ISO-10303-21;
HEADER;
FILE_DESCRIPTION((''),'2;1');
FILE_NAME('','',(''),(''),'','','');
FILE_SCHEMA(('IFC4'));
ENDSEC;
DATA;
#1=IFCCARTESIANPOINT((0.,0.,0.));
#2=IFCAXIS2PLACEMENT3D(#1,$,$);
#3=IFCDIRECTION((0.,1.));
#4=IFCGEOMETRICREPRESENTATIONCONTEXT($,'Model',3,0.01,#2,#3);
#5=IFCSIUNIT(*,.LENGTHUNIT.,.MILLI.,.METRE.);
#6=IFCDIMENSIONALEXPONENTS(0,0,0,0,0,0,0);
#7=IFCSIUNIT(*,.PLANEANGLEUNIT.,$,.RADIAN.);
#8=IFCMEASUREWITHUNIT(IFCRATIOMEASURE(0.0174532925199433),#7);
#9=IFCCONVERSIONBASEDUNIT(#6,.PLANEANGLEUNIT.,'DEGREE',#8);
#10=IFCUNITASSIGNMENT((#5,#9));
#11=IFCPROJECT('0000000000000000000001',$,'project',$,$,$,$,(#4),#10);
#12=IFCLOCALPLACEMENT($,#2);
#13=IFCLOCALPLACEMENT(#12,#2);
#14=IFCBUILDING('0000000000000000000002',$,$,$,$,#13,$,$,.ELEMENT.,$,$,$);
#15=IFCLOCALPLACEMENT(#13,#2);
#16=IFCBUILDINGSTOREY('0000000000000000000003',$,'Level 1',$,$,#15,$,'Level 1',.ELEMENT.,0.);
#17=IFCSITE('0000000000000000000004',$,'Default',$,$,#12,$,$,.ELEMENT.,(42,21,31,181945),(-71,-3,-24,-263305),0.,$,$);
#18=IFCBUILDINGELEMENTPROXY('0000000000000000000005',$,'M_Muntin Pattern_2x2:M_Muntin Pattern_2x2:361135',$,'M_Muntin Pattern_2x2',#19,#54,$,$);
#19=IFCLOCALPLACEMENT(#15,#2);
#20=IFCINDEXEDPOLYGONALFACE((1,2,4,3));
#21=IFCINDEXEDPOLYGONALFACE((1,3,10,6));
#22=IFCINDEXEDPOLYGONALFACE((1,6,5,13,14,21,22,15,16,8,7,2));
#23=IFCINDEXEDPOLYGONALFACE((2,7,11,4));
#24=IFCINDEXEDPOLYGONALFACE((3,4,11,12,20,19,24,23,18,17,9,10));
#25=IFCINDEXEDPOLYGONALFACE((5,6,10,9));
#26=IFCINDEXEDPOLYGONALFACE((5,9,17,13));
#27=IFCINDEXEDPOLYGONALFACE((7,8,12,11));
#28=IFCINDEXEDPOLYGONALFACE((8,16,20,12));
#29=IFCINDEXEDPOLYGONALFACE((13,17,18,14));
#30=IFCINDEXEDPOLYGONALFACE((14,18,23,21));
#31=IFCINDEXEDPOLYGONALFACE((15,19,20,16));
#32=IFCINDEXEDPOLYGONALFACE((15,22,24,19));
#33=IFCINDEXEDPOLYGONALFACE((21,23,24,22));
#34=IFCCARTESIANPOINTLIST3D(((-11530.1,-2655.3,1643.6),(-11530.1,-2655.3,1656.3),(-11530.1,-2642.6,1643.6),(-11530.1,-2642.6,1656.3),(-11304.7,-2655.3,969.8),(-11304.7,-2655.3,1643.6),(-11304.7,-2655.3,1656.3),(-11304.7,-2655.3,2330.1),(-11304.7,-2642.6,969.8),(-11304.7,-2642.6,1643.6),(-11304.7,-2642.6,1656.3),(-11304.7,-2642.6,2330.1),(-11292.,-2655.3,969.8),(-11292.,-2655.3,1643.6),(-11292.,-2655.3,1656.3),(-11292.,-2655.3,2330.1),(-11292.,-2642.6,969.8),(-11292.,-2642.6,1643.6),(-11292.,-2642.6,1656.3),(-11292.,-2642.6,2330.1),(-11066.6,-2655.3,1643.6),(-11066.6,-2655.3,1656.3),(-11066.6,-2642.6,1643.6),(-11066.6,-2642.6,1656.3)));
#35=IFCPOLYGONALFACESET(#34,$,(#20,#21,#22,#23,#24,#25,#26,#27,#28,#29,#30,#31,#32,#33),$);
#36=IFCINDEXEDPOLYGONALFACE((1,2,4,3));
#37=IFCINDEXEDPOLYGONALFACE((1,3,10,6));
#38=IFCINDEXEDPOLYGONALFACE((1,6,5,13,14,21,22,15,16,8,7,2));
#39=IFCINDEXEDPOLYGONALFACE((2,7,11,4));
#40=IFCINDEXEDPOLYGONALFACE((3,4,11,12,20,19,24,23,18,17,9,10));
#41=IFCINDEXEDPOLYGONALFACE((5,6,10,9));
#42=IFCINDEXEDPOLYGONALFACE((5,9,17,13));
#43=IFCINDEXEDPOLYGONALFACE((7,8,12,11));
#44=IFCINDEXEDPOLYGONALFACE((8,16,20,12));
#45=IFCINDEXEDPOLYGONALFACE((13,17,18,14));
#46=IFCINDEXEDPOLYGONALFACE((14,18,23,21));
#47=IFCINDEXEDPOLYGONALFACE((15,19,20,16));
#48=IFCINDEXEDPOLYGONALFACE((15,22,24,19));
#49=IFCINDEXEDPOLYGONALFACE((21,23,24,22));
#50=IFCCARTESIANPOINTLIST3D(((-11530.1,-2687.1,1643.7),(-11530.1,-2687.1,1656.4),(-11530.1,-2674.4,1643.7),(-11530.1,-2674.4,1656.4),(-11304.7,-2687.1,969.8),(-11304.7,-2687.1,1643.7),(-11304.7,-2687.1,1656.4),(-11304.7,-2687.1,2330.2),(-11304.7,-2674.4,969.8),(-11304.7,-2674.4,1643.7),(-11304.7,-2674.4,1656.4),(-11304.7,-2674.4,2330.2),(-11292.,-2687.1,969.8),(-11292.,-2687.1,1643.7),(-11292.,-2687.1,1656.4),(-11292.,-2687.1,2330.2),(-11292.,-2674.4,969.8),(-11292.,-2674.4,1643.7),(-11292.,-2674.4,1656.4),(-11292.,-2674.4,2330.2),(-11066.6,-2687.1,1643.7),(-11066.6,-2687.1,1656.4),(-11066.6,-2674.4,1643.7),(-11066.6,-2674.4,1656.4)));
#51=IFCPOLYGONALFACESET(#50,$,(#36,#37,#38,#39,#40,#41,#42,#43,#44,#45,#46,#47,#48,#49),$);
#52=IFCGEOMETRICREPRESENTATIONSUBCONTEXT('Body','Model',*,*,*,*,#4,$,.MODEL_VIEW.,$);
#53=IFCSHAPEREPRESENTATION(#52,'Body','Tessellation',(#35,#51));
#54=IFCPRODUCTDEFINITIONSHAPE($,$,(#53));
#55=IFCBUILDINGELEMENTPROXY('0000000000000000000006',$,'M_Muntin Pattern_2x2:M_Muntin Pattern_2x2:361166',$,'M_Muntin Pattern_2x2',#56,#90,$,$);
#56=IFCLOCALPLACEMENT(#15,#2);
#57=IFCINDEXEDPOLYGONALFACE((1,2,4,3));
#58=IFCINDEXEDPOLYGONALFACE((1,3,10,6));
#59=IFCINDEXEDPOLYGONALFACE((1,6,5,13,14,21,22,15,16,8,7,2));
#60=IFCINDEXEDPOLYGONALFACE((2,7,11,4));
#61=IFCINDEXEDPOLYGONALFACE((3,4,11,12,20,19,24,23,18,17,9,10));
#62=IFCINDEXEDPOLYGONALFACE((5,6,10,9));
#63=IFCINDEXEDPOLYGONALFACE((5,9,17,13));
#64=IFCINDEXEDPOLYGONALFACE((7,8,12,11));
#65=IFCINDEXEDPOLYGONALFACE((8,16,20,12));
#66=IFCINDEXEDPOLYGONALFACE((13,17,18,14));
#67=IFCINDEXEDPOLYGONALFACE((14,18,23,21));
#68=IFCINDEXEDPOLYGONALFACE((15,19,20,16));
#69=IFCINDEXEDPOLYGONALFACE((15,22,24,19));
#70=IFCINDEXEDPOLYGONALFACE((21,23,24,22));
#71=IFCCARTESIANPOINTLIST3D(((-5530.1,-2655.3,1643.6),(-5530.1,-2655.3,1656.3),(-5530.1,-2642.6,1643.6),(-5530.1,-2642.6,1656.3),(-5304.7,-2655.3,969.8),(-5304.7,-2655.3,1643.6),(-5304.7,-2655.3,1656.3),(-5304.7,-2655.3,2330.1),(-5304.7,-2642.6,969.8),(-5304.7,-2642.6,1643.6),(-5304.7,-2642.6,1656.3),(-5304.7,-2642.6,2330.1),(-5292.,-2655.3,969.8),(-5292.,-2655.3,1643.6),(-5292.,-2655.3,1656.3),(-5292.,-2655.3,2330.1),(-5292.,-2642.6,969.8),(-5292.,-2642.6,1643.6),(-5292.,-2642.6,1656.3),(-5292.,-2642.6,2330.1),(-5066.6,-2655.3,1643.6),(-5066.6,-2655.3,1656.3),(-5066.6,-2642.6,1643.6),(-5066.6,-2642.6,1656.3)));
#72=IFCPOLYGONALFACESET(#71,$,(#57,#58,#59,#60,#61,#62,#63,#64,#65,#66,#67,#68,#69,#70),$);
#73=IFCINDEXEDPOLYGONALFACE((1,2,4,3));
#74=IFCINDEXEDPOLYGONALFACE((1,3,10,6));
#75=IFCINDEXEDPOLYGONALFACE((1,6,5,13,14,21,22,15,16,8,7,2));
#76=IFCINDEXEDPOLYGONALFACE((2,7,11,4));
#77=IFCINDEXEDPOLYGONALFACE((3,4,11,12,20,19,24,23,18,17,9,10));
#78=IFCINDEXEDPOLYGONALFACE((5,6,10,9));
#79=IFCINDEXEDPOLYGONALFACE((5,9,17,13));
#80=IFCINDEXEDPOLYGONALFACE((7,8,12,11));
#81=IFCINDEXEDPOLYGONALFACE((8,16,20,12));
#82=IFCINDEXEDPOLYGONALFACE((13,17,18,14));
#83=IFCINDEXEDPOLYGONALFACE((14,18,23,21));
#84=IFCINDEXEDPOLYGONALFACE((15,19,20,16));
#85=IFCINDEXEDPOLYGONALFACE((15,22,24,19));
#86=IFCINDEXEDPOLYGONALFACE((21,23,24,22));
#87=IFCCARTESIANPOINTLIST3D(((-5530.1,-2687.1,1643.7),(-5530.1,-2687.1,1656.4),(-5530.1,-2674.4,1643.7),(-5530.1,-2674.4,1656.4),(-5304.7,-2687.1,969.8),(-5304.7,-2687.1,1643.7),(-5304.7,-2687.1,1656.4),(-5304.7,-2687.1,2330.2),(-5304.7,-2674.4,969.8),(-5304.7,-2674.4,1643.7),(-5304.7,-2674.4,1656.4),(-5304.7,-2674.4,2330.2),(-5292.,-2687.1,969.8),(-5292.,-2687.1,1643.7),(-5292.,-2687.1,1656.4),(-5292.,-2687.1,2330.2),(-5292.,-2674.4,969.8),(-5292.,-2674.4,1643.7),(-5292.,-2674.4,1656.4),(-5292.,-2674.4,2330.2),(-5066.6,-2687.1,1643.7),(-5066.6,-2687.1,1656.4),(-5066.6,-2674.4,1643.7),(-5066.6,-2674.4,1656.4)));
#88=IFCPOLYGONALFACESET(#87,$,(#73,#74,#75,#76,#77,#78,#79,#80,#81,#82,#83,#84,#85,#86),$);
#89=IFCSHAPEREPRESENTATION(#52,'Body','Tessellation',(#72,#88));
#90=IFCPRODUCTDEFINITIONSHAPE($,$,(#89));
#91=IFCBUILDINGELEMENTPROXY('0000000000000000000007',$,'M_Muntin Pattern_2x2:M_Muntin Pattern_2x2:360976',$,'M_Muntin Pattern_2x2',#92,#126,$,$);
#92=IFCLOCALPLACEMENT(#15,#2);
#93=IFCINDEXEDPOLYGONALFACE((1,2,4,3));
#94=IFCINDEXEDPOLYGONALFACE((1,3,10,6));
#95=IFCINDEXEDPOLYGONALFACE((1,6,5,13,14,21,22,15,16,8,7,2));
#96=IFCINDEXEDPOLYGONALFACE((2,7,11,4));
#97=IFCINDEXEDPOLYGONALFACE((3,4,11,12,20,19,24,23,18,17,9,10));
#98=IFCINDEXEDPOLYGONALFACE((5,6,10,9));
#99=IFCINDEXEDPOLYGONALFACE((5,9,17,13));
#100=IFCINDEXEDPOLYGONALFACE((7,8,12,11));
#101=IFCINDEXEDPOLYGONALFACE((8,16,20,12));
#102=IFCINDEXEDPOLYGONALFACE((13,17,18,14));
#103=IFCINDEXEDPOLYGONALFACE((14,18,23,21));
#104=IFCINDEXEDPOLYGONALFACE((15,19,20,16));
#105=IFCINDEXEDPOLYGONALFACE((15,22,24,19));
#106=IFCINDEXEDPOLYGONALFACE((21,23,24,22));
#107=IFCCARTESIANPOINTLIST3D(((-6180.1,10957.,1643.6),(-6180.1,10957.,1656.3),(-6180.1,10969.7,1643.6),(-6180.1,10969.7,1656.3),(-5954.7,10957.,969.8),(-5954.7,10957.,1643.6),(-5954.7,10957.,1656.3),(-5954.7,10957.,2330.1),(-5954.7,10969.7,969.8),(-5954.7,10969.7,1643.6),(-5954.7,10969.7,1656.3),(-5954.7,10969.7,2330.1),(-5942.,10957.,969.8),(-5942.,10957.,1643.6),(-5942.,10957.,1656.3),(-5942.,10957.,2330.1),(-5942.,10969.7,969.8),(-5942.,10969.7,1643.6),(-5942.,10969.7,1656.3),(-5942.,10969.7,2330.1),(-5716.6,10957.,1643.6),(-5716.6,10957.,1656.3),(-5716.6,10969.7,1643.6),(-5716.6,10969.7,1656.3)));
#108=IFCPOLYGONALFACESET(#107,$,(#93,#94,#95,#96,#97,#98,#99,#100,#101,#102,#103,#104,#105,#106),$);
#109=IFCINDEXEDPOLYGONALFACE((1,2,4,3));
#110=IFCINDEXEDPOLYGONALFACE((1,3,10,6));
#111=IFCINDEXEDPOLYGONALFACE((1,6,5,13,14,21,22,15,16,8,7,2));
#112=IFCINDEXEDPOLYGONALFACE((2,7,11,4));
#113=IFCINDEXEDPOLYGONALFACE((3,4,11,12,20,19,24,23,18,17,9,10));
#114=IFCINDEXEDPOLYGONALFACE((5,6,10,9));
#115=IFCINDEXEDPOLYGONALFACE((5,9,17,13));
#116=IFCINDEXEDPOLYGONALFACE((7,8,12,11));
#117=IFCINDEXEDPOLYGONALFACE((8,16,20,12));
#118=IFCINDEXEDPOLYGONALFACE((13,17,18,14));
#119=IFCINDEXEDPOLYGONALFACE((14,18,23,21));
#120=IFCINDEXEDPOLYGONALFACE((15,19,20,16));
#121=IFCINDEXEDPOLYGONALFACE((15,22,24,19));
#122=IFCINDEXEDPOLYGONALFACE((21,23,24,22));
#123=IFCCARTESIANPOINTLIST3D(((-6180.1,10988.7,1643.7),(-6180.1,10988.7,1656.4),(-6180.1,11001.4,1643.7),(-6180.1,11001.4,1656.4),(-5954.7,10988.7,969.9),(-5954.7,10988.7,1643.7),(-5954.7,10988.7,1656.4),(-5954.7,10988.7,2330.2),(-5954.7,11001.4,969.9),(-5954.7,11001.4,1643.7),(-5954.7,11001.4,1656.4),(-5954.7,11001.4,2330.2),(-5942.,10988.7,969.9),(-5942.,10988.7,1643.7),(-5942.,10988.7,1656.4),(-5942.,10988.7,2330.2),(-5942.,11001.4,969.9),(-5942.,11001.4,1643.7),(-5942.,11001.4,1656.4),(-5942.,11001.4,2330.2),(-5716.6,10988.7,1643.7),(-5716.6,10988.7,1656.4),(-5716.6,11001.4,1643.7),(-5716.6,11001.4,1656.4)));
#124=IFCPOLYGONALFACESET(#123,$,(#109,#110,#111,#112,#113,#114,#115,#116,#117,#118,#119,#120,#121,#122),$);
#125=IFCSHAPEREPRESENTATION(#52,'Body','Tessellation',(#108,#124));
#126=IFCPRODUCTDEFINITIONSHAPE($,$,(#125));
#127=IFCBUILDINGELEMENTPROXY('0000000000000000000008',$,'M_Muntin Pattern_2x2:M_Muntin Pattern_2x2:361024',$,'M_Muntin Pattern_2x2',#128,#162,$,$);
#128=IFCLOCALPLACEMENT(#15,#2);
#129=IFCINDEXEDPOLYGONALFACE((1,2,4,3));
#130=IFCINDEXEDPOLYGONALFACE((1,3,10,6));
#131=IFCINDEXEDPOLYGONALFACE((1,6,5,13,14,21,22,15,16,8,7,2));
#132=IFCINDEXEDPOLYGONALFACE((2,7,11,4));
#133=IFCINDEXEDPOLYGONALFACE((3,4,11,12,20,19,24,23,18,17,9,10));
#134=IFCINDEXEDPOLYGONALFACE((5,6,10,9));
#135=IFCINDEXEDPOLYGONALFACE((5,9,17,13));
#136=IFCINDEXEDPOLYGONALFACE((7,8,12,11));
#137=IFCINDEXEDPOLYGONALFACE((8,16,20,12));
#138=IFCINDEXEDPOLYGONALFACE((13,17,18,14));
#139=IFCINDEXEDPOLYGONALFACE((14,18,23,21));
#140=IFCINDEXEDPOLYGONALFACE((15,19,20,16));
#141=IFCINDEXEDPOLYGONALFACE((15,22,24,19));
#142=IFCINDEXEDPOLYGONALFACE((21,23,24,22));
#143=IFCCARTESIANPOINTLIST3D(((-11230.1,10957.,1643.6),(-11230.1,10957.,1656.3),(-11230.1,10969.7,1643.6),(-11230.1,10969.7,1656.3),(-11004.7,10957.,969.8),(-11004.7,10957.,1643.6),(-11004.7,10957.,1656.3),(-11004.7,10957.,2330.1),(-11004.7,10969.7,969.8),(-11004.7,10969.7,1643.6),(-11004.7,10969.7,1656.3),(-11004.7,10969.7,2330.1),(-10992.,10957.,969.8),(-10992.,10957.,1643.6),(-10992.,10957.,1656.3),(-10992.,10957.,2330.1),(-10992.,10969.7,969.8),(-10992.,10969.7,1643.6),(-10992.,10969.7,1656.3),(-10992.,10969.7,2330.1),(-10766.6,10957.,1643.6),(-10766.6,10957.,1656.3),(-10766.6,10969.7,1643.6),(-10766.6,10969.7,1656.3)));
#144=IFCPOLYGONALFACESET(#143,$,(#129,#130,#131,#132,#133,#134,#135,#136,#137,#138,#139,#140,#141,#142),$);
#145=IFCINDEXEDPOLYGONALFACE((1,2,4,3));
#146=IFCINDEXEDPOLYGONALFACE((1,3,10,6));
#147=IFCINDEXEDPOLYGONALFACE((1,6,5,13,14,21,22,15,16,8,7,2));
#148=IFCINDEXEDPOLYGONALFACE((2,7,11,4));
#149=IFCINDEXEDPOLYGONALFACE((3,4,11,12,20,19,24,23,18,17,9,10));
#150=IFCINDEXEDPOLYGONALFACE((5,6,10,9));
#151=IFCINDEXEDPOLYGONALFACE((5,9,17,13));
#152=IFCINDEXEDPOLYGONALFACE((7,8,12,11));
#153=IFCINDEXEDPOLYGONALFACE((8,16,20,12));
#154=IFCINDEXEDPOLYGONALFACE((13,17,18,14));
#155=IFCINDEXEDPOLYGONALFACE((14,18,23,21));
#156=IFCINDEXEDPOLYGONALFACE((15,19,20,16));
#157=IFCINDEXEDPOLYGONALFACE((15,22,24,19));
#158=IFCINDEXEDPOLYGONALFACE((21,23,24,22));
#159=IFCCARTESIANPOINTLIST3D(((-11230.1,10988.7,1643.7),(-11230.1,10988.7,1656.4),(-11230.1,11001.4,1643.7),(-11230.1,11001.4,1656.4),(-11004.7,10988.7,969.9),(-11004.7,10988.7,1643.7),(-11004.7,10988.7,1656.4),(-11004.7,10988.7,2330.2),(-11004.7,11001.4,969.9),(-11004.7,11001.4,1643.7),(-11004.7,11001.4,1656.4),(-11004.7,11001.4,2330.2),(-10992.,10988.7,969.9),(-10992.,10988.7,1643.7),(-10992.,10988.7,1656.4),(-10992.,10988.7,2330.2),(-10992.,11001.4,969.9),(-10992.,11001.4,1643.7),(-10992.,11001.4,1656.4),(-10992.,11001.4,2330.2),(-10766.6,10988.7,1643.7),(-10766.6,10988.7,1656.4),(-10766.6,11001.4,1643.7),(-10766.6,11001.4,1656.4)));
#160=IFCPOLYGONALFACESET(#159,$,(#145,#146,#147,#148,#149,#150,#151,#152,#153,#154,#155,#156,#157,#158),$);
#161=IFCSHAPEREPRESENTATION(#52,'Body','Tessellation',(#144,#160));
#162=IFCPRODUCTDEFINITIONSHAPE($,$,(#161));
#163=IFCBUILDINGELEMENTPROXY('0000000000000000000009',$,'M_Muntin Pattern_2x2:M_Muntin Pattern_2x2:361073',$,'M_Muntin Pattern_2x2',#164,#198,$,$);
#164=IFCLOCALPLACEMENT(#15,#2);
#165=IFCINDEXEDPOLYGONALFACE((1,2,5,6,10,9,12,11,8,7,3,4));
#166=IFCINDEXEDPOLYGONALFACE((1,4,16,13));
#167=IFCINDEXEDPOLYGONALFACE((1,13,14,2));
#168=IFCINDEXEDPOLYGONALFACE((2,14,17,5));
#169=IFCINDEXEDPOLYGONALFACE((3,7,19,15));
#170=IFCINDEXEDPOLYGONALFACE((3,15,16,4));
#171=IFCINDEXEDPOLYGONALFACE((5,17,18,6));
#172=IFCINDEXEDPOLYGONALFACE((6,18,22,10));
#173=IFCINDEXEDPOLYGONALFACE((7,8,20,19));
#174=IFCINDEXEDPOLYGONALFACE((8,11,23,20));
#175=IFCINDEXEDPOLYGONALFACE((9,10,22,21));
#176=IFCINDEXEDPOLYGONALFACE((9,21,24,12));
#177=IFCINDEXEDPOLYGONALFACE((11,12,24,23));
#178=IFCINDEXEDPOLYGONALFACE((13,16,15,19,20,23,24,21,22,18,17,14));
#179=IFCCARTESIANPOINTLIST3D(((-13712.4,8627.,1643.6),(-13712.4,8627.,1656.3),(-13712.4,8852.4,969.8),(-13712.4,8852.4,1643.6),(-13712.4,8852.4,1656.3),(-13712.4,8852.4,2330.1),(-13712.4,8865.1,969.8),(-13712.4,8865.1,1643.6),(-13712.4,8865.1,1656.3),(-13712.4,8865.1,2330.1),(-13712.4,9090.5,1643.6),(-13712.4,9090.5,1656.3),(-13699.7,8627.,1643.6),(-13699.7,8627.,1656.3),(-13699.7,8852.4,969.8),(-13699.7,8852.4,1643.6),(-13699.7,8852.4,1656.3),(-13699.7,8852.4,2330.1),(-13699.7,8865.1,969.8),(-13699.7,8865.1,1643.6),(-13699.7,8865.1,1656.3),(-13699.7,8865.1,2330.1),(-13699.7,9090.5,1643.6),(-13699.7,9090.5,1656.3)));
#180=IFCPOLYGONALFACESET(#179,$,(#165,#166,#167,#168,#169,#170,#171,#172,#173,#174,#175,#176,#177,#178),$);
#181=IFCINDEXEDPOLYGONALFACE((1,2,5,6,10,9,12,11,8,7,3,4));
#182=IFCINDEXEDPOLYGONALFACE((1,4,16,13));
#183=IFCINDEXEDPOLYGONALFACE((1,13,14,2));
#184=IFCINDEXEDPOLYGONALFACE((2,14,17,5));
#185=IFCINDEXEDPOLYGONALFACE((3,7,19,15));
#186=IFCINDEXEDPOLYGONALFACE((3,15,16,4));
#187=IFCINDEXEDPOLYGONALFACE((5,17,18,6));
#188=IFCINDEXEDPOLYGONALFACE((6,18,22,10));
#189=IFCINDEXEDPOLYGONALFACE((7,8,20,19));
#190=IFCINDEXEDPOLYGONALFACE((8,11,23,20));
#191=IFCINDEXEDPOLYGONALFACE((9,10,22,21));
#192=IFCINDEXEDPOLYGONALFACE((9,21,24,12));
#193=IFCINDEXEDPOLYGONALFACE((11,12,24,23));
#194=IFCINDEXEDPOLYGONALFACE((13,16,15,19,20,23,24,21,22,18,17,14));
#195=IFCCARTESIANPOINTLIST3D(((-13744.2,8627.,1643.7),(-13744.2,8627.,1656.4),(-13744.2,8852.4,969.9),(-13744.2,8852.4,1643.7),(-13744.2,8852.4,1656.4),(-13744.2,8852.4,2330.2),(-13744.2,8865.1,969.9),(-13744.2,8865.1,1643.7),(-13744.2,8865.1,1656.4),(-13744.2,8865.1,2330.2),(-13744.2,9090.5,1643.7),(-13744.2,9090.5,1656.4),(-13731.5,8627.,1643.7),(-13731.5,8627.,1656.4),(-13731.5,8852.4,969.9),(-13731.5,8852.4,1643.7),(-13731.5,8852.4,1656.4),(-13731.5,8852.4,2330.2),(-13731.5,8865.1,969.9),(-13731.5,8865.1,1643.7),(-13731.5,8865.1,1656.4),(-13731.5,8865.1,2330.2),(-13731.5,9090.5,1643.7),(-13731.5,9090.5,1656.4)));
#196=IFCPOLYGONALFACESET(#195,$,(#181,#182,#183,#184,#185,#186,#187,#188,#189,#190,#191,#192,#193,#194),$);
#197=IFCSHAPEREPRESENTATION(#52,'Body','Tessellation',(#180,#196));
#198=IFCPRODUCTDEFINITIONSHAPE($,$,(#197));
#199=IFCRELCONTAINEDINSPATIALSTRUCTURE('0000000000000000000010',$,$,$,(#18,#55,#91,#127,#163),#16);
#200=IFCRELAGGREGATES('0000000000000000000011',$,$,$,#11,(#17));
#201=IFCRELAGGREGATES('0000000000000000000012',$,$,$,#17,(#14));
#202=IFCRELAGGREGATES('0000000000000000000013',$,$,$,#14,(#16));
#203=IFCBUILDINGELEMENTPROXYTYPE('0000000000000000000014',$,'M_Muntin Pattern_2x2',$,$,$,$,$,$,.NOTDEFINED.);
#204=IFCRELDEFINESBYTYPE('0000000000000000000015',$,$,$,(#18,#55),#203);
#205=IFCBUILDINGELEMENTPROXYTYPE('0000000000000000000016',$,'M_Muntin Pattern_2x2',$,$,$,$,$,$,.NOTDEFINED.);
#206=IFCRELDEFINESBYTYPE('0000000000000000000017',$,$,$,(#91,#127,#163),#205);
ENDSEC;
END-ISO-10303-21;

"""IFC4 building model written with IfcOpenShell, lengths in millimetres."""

from ifc_helpers import new_model, entity, si_unit, converted_unit, direction, frame, origin, place, context, subcontext, project, spatial, polyline, outline, extrude, source, transform, mapped, type_object, type_shapes, element, save


model = new_model("IFC4")

# Units and contexts
model_context = context("Model", 3, precision=0.01, world=origin(), true_north=direction((0.0, 1.0)))
body_context = subcontext(model_context, "Body", "Model", "MODEL_VIEW")
ifc_project = project(units=[si_unit("LENGTHUNIT", "METRE", prefix="MILLI"), converted_unit("PLANEANGLEUNIT", "DEGREE", entity("IfcRatioMeasure", 0.0174532925199433), si_unit("PLANEANGLEUNIT", "RADIAN"), dimensions=[0, 0, 0, 0, 0, 0, 0])], contexts=[model_context])

# Site, building, storey
site_placement = place(None, origin())
site = spatial("IfcSite", under=ifc_project, at=site_placement, Name="Default", CompositionType="ELEMENT", RefLatitude=(42, 21, 31, 181945), RefLongitude=(-71, -3, -24, -263305), RefElevation=0.0)
building_placement = place(site_placement, origin())
building = spatial("IfcBuilding", under=site, at=building_placement, CompositionType="ELEMENT")
storey_placement = place(building_placement, origin())
storey = spatial("IfcBuildingStorey", under=building, at=storey_placement, Name="Level 1", LongName="Level 1", CompositionType="ELEMENT", Elevation=0.0)

# Building element proxies
building_element_proxy_type_1 = type_object("IfcBuildingElementProxyType", Name="M_Muntin Pattern_2x2", PredefinedType="NOTDEFINED")
shared_shape_1 = source(origin(), body_context, "Body", "SweptSolid", [
    extrude(outline(polyline([(6.4, -6.4), (680.1, -6.4), (680.1, 6.3), (6.4, 6.3), (6.4, 231.7), (-6.3, 231.7), (-6.3, 6.3), (-680.2, 6.3), (-680.2, -6.4), (-6.3, -6.4), (-6.3, -231.7), (6.4, -231.7), (6.4, -6.4)])), frame((0.0, 9.5, 680.1), z_axis=(0.0, 1.0, 0.0), x_axis=(0.0, 0.0, 1.0)), (0.0, 0.0, 1.0), 12.7),
    extrude(outline(polyline([(6.4, -6.4), (680.2, -6.4), (680.2, 6.3), (6.4, 6.3), (6.4, 231.7), (-6.3, 231.7), (-6.3, 6.3), (-680.2, 6.3), (-680.2, -6.4), (-6.3, -6.4), (-6.3, -231.7), (6.4, -231.7), (6.4, -6.4)])), frame((0.0, -22.2, 680.2), z_axis=(0.0, 1.0, 0.0), x_axis=(0.0, 0.0, 1.0)), (0.0, 0.0, 1.0), 12.7),
])
type_shapes(building_element_proxy_type_1, [shared_shape_1])
for number, where, name in (
    (1, (-11298.4, -2664.9, 969.8), "M_Muntin Pattern_2x2:M_Muntin Pattern_2x2:361135"),
    (2, (-5298.4, -2664.9, 969.8), "M_Muntin Pattern_2x2:M_Muntin Pattern_2x2:361166"),
):
    element("IfcBuildingElementProxy", number, at=place(storey_placement, frame(where)), inside=storey, type_object=building_element_proxy_type_1, Name=name, ObjectType="M_Muntin Pattern_2x2", context=body_context, shape_type="MappedRepresentation", body=[
        mapped(shared_shape_1, transform((0.0, 0.0, 0.0), scale=1.0)),
    ])
building_element_proxy_type_2 = type_object("IfcBuildingElementProxyType", Name="M_Muntin Pattern_2x2", PredefinedType="NOTDEFINED")
shared_shape_2 = source(origin(), body_context, "Body", "SweptSolid", [
    extrude(outline(polyline([(6.4, -6.4), (680.1, -6.4), (680.1, 6.3), (6.4, 6.3), (6.4, 231.7), (-6.3, 231.7), (-6.3, 6.3), (-680.2, 6.3), (-680.2, -6.4), (-6.3, -6.4), (-6.3, -231.7), (6.4, -231.7), (6.4, -6.4)])), frame((0.0, -22.2, 680.1), z_axis=(0.0, 1.0, 0.0), x_axis=(0.0, 0.0, 1.0)), (0.0, 0.0, 1.0), 12.7),
    extrude(outline(polyline([(6.4, -6.4), (680.1, -6.4), (680.1, 6.3), (6.4, 6.3), (6.4, 231.7), (-6.3, 231.7), (-6.3, 6.3), (-680.2, 6.3), (-680.2, -6.4), (-6.3, -6.4), (-6.3, -231.7), (6.4, -231.7), (6.4, -6.4)])), frame((0.0, 9.5, 680.2), z_axis=(0.0, 1.0, 0.0), x_axis=(0.0, 0.0, 1.0)), (0.0, 0.0, 1.0), 12.7),
])
type_shapes(building_element_proxy_type_2, [shared_shape_2])
for number, where, name in (
    (3, (-5948.4, 10979.2, 969.9), "M_Muntin Pattern_2x2:M_Muntin Pattern_2x2:360976"),
    (4, (-10998.4, 10979.2, 969.9), "M_Muntin Pattern_2x2:M_Muntin Pattern_2x2:361024"),
):
    element("IfcBuildingElementProxy", number, at=place(storey_placement, frame(where)), inside=storey, type_object=building_element_proxy_type_2, Name=name, ObjectType="M_Muntin Pattern_2x2", context=body_context, shape_type="MappedRepresentation", body=[
        mapped(shared_shape_2, transform((0.0, 0.0, 0.0), scale=1.0)),
    ])
for number, where, z_axis, x_axis, name in (
    (5, (-13722.0, 8858.7, 969.9), (0.0, 0.0, 1.0), (0.0, 1.0, 0.0), "M_Muntin Pattern_2x2:M_Muntin Pattern_2x2:361073"),
):
    element("IfcBuildingElementProxy", number, at=place(storey_placement, frame(where, z_axis=z_axis, x_axis=x_axis)), inside=storey, type_object=building_element_proxy_type_2, Name=name, ObjectType="M_Muntin Pattern_2x2", context=body_context, shape_type="MappedRepresentation", body=[
        mapped(shared_shape_2, transform((0.0, 0.0, 0.0), scale=1.0)),
    ])

save(model, "model.ifc")
